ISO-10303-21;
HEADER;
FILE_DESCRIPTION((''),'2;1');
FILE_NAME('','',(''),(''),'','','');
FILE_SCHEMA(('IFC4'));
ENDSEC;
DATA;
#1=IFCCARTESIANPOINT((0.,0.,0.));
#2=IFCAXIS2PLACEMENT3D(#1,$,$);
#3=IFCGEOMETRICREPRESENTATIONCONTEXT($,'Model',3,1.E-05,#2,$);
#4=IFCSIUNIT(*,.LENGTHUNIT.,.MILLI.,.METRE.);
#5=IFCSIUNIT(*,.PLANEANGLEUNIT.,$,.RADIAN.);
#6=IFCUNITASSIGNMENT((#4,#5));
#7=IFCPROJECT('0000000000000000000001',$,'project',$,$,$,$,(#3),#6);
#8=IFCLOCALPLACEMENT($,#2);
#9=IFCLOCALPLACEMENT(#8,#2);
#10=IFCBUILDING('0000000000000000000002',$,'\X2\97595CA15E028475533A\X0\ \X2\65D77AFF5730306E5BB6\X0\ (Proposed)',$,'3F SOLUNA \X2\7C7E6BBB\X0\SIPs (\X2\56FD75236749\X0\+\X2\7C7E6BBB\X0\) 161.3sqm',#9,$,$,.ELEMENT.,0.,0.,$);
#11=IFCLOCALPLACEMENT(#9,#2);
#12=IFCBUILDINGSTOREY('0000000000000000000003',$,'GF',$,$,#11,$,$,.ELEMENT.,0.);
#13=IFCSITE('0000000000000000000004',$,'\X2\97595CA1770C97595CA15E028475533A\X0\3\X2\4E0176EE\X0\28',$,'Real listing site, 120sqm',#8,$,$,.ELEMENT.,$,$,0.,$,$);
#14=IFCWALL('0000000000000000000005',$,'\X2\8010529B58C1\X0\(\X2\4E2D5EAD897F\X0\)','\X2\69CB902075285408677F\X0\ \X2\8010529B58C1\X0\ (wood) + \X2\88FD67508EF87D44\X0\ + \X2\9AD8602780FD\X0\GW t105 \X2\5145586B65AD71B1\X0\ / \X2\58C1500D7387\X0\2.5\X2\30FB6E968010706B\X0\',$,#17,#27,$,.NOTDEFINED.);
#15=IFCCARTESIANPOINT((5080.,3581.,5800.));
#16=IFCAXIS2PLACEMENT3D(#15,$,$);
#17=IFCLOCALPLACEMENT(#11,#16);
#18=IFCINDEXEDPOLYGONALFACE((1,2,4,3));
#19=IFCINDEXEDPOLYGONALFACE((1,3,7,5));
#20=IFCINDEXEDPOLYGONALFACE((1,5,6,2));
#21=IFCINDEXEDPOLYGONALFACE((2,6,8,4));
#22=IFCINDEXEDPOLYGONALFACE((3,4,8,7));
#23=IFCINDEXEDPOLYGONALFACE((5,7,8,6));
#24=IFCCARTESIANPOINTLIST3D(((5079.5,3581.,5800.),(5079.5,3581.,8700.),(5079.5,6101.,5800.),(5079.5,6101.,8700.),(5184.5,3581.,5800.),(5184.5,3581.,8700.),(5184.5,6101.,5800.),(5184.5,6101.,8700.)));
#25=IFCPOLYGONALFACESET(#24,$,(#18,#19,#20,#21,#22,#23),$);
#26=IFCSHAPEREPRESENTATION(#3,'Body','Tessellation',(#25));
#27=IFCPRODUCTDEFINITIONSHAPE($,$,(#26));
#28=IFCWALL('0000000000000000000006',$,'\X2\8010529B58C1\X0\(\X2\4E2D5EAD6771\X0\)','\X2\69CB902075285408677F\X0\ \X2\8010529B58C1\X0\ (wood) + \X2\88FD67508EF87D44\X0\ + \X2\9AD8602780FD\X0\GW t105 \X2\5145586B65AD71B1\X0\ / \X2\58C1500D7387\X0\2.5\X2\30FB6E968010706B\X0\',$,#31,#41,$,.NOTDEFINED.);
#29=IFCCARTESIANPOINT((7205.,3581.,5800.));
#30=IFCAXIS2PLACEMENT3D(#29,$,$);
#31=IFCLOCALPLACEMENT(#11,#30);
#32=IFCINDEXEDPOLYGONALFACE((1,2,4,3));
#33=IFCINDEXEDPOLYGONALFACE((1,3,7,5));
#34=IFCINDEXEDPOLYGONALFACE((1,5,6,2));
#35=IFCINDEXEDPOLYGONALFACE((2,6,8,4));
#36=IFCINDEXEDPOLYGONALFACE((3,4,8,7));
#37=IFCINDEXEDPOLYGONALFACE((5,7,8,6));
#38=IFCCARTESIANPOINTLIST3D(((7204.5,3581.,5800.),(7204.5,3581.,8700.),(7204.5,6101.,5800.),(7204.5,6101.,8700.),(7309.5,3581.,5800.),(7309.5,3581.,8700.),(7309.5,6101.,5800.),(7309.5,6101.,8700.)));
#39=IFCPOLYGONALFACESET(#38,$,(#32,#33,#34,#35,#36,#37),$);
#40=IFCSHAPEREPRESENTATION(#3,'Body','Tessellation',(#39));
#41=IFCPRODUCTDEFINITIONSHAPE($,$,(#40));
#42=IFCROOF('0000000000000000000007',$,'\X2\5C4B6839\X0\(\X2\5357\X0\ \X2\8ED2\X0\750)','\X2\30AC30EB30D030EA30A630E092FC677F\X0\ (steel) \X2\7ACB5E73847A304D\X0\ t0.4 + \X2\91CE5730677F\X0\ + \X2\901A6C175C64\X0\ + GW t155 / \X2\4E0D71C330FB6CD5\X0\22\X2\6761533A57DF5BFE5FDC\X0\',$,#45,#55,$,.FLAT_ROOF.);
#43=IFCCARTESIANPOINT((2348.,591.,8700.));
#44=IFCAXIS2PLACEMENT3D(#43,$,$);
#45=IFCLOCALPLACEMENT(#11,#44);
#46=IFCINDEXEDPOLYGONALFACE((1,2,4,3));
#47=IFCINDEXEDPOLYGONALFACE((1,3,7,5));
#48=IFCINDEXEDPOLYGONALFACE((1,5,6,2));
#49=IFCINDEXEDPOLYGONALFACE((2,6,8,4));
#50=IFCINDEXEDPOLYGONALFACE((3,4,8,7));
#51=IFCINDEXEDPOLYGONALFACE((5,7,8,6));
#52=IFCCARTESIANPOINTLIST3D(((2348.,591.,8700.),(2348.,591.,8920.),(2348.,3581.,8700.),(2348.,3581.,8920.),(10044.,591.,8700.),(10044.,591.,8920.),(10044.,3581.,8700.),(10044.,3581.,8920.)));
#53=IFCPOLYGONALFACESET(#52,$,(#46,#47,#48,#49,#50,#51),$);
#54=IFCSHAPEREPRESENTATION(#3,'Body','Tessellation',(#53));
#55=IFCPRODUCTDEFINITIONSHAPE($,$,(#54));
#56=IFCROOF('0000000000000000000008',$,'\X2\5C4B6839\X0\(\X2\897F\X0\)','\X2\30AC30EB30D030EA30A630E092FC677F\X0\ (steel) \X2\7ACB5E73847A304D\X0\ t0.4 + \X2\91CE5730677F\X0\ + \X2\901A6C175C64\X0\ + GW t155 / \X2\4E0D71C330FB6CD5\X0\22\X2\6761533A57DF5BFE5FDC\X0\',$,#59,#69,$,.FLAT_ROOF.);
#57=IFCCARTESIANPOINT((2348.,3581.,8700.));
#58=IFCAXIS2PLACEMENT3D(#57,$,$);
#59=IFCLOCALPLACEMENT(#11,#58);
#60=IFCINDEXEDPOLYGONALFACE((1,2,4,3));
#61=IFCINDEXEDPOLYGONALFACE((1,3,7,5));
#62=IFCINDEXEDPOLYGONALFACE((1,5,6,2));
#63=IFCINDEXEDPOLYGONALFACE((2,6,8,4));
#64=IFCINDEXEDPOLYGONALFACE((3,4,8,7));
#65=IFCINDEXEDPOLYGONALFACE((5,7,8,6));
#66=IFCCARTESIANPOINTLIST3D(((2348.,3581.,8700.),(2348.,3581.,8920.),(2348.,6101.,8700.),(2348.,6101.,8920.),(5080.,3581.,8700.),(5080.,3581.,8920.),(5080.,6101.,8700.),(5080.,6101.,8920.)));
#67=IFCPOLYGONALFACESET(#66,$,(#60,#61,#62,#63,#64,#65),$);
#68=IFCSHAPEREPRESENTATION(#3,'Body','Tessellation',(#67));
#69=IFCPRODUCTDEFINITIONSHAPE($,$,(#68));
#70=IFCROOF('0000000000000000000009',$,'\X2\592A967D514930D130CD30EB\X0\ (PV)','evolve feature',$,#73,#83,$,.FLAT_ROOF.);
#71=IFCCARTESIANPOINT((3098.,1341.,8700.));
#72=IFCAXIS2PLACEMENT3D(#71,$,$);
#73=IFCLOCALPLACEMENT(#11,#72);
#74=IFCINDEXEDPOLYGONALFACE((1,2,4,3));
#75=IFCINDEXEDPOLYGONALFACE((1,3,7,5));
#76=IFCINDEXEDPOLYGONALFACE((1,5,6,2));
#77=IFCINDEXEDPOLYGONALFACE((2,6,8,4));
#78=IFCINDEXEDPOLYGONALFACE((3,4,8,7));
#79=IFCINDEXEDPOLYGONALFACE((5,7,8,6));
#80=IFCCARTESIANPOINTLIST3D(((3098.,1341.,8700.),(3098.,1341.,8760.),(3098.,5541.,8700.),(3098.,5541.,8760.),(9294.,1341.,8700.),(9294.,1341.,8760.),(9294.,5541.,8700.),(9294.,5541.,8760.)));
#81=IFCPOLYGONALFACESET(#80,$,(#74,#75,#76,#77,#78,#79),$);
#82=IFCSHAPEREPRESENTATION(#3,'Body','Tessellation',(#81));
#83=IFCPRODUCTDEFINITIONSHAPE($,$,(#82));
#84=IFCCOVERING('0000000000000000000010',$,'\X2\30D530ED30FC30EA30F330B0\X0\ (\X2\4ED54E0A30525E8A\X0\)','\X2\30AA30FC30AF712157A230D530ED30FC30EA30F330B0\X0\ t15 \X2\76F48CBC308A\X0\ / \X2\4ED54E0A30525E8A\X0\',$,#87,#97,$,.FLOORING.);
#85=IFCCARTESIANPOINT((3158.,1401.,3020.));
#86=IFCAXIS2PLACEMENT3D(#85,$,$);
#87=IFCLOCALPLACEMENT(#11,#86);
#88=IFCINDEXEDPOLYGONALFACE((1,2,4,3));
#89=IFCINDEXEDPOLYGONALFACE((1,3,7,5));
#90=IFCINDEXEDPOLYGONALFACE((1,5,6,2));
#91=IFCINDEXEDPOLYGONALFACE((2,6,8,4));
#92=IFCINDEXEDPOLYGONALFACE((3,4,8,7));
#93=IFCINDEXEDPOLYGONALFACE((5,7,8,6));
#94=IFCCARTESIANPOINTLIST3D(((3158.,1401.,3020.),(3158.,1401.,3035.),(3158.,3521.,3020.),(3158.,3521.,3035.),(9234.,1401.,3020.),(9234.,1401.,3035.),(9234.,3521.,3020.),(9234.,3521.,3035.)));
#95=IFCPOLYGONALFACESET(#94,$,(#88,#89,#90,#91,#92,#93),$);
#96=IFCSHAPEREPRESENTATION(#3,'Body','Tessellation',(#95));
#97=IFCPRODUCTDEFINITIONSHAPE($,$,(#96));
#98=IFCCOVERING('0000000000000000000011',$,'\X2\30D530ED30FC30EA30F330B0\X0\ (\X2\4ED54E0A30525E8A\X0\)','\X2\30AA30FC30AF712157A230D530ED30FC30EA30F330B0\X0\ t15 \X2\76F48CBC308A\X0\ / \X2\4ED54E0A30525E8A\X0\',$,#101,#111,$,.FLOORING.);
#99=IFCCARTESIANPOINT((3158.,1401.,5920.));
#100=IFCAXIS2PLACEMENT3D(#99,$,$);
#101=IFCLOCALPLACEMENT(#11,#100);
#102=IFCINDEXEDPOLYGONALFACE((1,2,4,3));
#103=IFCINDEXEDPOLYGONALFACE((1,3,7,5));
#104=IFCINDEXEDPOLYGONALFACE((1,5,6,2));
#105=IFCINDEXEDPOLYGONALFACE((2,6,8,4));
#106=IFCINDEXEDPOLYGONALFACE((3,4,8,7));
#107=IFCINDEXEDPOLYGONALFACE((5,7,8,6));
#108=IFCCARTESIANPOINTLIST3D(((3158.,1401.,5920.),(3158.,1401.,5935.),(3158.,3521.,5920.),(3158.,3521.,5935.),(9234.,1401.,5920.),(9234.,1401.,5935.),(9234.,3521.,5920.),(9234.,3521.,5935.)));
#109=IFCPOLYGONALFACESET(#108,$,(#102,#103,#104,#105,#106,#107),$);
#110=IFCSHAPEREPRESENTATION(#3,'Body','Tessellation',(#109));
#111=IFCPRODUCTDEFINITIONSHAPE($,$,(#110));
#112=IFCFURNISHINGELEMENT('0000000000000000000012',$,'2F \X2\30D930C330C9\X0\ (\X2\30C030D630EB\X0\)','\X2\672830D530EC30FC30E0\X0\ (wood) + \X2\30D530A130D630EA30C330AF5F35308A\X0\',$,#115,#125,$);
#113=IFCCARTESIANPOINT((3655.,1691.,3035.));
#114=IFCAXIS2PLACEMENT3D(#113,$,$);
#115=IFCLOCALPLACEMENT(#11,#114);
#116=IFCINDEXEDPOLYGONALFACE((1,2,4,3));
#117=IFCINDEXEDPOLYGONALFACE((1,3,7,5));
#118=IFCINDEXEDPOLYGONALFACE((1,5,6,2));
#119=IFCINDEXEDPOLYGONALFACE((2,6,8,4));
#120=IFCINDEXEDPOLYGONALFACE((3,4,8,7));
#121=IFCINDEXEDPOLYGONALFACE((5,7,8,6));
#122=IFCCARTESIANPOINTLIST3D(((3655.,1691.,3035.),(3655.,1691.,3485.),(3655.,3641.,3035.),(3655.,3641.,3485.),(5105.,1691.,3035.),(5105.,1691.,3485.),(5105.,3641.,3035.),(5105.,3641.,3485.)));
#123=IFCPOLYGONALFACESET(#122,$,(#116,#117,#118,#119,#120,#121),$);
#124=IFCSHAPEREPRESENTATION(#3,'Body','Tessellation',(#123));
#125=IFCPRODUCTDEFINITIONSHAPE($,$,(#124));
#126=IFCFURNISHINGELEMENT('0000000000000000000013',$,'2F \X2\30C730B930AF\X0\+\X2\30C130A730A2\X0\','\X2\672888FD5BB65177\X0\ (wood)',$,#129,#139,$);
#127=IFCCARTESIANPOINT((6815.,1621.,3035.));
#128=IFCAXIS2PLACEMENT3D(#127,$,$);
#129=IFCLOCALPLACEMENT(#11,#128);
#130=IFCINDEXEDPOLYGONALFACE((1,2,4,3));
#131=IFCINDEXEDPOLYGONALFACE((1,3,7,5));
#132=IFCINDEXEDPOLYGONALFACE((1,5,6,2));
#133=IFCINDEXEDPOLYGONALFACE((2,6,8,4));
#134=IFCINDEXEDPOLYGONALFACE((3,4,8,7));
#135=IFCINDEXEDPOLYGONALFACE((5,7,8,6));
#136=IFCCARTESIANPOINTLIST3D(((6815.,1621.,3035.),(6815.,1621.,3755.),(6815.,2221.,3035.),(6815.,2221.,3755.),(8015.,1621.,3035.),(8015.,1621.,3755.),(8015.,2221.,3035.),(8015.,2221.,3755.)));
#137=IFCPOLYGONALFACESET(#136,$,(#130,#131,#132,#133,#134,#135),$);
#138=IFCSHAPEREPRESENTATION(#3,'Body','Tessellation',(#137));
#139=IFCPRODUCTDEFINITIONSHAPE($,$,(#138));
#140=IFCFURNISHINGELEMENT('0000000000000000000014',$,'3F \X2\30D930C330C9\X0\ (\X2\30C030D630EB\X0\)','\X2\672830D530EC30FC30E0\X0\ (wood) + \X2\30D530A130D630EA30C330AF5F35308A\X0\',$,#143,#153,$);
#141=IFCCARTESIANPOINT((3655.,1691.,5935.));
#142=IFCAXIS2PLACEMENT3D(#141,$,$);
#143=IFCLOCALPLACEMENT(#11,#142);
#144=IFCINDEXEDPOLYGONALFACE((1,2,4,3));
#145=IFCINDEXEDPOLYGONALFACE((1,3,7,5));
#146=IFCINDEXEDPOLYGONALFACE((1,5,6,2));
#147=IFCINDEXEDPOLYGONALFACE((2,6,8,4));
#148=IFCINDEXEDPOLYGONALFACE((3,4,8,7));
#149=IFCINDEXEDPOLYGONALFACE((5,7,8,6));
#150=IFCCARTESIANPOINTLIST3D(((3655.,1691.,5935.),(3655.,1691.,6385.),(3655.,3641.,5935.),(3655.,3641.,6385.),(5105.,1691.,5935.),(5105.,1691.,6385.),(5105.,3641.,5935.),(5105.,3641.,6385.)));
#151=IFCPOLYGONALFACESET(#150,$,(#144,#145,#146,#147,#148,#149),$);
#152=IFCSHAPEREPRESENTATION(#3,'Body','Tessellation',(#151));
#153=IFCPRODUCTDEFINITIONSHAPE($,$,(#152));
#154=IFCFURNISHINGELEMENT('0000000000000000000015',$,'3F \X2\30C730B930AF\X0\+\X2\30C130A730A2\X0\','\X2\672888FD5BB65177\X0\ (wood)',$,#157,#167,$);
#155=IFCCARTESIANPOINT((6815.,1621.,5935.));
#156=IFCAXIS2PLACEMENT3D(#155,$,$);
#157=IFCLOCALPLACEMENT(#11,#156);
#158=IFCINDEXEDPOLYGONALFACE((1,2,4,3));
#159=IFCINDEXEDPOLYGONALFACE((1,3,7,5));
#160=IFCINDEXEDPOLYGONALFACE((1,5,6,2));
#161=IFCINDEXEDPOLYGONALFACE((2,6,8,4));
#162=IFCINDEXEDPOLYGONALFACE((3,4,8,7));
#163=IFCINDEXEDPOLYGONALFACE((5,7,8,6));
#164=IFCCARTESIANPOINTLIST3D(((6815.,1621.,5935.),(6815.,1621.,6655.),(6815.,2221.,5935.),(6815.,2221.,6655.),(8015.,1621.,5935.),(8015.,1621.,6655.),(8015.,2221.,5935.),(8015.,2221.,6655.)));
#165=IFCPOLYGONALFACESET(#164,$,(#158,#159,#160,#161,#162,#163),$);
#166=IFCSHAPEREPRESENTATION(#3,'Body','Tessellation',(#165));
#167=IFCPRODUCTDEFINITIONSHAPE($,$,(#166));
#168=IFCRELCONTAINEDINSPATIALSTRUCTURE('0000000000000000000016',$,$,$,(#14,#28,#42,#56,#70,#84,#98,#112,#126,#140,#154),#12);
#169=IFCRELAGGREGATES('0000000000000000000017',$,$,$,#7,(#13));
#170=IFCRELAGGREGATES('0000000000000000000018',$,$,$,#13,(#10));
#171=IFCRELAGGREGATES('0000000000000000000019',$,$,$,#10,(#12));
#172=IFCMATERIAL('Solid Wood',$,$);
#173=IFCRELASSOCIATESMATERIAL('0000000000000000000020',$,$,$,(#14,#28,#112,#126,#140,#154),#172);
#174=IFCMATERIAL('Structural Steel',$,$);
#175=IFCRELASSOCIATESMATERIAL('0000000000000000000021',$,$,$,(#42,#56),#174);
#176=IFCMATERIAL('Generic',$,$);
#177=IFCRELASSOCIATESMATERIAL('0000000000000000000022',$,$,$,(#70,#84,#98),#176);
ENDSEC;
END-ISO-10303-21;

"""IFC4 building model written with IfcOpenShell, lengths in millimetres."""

from ifc_helpers import new_model, si_unit, frame, frame_2d, origin, place, context, project, spatial, rectangle, extrude, material, element, save


model = new_model("IFC4")

# Units and contexts
model_context = context("Model", 3, precision=1e-05, world=origin())
ifc_project = project(units=[si_unit("LENGTHUNIT", "METRE", prefix="MILLI"), si_unit("PLANEANGLEUNIT", "RADIAN")], contexts=[model_context])

# Site, building, storey
site_placement = place(None, origin())
site = spatial("IfcSite", under=ifc_project, at=site_placement, Name="静岡県静岡市葵区3丁目28", ObjectType="Real listing site, 120sqm", CompositionType="ELEMENT", RefElevation=0.0)
building_placement = place(site_placement, origin())
building = spatial("IfcBuilding", under=site, at=building_placement, Name="静岡市葵区 旗竿地の家 (Proposed)", ObjectType="3F SOLUNA 籾殻SIPs (国産杉+籾殻) 161.3sqm", CompositionType="ELEMENT", ElevationOfRefHeight=0.0, ElevationOfTerrain=0.0)
storey_placement = place(building_placement, origin())
storey = spatial("IfcBuildingStorey", under=building, at=storey_placement, Name="GF", CompositionType="ELEMENT", Elevation=0.0)

# Shared definitions
ifc_material_1 = material(Name="Solid Wood")

# Walls
wall_1_placement = place(storey_placement, frame((5080.0, 3581.0, 5800.0)))
element("IfcWall", 1, at=wall_1_placement, inside=storey, material=ifc_material_1, Name="耐力壁(中庭西)", Description="構造用合板 耐力壁 (wood) + 製材軸組 + 高性能GW t105 充填断熱 / 壁倍率2.5・準耐火", PredefinedType="NOTDEFINED", context=model_context, shape_type="SweptSolid", body=[
    extrude(rectangle(XDim=105.0, YDim=2520.0, at=frame_2d((52.0, 1260.0))), frame((5080.0, 3581.0, 5800.0)), (0.0, 0.0, 1.0), 2900.0),
])
wall_2_placement = place(storey_placement, frame((7205.0, 3581.0, 5800.0)))
element("IfcWall", 2, at=wall_2_placement, inside=storey, material=ifc_material_1, Name="耐力壁(中庭東)", Description="構造用合板 耐力壁 (wood) + 製材軸組 + 高性能GW t105 充填断熱 / 壁倍率2.5・準耐火", PredefinedType="NOTDEFINED", context=model_context, shape_type="SweptSolid", body=[
    extrude(rectangle(XDim=105.0, YDim=2520.0, at=frame_2d((52.0, 1260.0))), frame((7205.0, 3581.0, 5800.0)), (0.0, 0.0, 1.0), 2900.0),
])

# Roofs
ifc_material_2 = material(Name="Structural Steel")
roof_1_placement = place(storey_placement, frame((2348.0, 591.0, 8700.0)))
element("IfcRoof", 3, at=roof_1_placement, inside=storey, material=ifc_material_2, Name="屋根(南 軒750)", Description="ガルバリウム鋼板 (steel) 立平葺き t0.4 + 野地板 + 通気層 + GW t155 / 不燃・法22条区域対応", PredefinedType="FLAT_ROOF", context=model_context, shape_type="SweptSolid", body=[
    extrude(rectangle(XDim=7696.0, YDim=2990.0, at=frame_2d((3848.0, 1495.0))), frame((2348.0, 591.0, 8700.0)), (0.0, 0.0, 1.0), 220.0),
])
roof_2_placement = place(storey_placement, frame((2348.0, 3581.0, 8700.0)))
element("IfcRoof", 4, at=roof_2_placement, inside=storey, material=ifc_material_2, Name="屋根(西)", Description="ガルバリウム鋼板 (steel) 立平葺き t0.4 + 野地板 + 通気層 + GW t155 / 不燃・法22条区域対応", PredefinedType="FLAT_ROOF", context=model_context, shape_type="SweptSolid", body=[
    extrude(rectangle(XDim=2732.0, YDim=2520.0, at=frame_2d((1366.0, 1260.0))), frame((2348.0, 3581.0, 8700.0)), (0.0, 0.0, 1.0), 220.0),
])
ifc_material_3 = material(Name="Generic")
roof_3_placement = place(storey_placement, frame((3098.0, 1341.0, 8700.0)))
element("IfcRoof", 5, at=roof_3_placement, inside=storey, material=ifc_material_3, Name="太陽光パネル (PV)", Description="evolve feature", PredefinedType="FLAT_ROOF", context=model_context, shape_type="SweptSolid", body=[
    extrude(rectangle(XDim=6196.0, YDim=4200.0, at=frame_2d((3098.0, 2100.0))), frame((3098.0, 1341.0, 8700.0)), (0.0, 0.0, 1.0), 60.0),
])

# Coverings
covering_1_placement = place(storey_placement, frame((3158.0, 1401.0, 3020.0)))
element("IfcCovering", 6, at=covering_1_placement, inside=storey, material=ifc_material_3, Name="フローリング (仕上げ床)", Description="オーク無垢フローリング t15 直貼り / 仕上げ床", PredefinedType="FLOORING", context=model_context, shape_type="SweptSolid", body=[
    extrude(rectangle(XDim=6076.0, YDim=2120.0, at=frame_2d((3038.0, 1060.0))), frame((3158.0, 1401.0, 3020.0)), (0.0, 0.0, 1.0), 15.0),
])
covering_2_placement = place(storey_placement, frame((3158.0, 1401.0, 5920.0)))
element("IfcCovering", 7, at=covering_2_placement, inside=storey, material=ifc_material_3, Name="フローリング (仕上げ床)", Description="オーク無垢フローリング t15 直貼り / 仕上げ床", PredefinedType="FLOORING", context=model_context, shape_type="SweptSolid", body=[
    extrude(rectangle(XDim=6076.0, YDim=2120.0, at=frame_2d((3038.0, 1060.0))), frame((3158.0, 1401.0, 5920.0)), (0.0, 0.0, 1.0), 15.0),
])

# Furnishing elements
furnishing_1_placement = place(storey_placement, frame((3655.0, 1691.0, 3035.0)))
element("IfcFurnishingElement", 8, at=furnishing_1_placement, inside=storey, material=ifc_material_1, Name="2F ベッド (ダブル)", Description="木フレーム (wood) + ファブリック張り", context=model_context, shape_type="SweptSolid", body=[
    extrude(rectangle(XDim=1450.0, YDim=1950.0, at=frame_2d((725.0, 975.0))), frame((3655.0, 1691.0, 3035.0)), (0.0, 0.0, 1.0), 450.0),
])
furnishing_2_placement = place(storey_placement, frame((6815.0, 1621.0, 3035.0)))
element("IfcFurnishingElement", 9, at=furnishing_2_placement, inside=storey, material=ifc_material_1, Name="2F デスク+チェア", Description="木製家具 (wood)", context=model_context, shape_type="SweptSolid", body=[
    extrude(rectangle(XDim=1200.0, YDim=600.0, at=frame_2d((600.0, 300.0))), frame((6815.0, 1621.0, 3035.0)), (0.0, 0.0, 1.0), 720.0),
])
furnishing_3_placement = place(storey_placement, frame((3655.0, 1691.0, 5935.0)))
element("IfcFurnishingElement", 10, at=furnishing_3_placement, inside=storey, material=ifc_material_1, Name="3F ベッド (ダブル)", Description="木フレーム (wood) + ファブリック張り", context=model_context, shape_type="SweptSolid", body=[
    extrude(rectangle(XDim=1450.0, YDim=1950.0, at=frame_2d((725.0, 975.0))), frame((3655.0, 1691.0, 5935.0)), (0.0, 0.0, 1.0), 450.0),
])
furnishing_4_placement = place(storey_placement, frame((6815.0, 1621.0, 5935.0)))
element("IfcFurnishingElement", 11, at=furnishing_4_placement, inside=storey, material=ifc_material_1, Name="3F デスク+チェア", Description="木製家具 (wood)", context=model_context, shape_type="SweptSolid", body=[
    extrude(rectangle(XDim=1200.0, YDim=600.0, at=frame_2d((600.0, 300.0))), frame((6815.0, 1621.0, 5935.0)), (0.0, 0.0, 1.0), 720.0),
])

save(model, "model.ifc")
